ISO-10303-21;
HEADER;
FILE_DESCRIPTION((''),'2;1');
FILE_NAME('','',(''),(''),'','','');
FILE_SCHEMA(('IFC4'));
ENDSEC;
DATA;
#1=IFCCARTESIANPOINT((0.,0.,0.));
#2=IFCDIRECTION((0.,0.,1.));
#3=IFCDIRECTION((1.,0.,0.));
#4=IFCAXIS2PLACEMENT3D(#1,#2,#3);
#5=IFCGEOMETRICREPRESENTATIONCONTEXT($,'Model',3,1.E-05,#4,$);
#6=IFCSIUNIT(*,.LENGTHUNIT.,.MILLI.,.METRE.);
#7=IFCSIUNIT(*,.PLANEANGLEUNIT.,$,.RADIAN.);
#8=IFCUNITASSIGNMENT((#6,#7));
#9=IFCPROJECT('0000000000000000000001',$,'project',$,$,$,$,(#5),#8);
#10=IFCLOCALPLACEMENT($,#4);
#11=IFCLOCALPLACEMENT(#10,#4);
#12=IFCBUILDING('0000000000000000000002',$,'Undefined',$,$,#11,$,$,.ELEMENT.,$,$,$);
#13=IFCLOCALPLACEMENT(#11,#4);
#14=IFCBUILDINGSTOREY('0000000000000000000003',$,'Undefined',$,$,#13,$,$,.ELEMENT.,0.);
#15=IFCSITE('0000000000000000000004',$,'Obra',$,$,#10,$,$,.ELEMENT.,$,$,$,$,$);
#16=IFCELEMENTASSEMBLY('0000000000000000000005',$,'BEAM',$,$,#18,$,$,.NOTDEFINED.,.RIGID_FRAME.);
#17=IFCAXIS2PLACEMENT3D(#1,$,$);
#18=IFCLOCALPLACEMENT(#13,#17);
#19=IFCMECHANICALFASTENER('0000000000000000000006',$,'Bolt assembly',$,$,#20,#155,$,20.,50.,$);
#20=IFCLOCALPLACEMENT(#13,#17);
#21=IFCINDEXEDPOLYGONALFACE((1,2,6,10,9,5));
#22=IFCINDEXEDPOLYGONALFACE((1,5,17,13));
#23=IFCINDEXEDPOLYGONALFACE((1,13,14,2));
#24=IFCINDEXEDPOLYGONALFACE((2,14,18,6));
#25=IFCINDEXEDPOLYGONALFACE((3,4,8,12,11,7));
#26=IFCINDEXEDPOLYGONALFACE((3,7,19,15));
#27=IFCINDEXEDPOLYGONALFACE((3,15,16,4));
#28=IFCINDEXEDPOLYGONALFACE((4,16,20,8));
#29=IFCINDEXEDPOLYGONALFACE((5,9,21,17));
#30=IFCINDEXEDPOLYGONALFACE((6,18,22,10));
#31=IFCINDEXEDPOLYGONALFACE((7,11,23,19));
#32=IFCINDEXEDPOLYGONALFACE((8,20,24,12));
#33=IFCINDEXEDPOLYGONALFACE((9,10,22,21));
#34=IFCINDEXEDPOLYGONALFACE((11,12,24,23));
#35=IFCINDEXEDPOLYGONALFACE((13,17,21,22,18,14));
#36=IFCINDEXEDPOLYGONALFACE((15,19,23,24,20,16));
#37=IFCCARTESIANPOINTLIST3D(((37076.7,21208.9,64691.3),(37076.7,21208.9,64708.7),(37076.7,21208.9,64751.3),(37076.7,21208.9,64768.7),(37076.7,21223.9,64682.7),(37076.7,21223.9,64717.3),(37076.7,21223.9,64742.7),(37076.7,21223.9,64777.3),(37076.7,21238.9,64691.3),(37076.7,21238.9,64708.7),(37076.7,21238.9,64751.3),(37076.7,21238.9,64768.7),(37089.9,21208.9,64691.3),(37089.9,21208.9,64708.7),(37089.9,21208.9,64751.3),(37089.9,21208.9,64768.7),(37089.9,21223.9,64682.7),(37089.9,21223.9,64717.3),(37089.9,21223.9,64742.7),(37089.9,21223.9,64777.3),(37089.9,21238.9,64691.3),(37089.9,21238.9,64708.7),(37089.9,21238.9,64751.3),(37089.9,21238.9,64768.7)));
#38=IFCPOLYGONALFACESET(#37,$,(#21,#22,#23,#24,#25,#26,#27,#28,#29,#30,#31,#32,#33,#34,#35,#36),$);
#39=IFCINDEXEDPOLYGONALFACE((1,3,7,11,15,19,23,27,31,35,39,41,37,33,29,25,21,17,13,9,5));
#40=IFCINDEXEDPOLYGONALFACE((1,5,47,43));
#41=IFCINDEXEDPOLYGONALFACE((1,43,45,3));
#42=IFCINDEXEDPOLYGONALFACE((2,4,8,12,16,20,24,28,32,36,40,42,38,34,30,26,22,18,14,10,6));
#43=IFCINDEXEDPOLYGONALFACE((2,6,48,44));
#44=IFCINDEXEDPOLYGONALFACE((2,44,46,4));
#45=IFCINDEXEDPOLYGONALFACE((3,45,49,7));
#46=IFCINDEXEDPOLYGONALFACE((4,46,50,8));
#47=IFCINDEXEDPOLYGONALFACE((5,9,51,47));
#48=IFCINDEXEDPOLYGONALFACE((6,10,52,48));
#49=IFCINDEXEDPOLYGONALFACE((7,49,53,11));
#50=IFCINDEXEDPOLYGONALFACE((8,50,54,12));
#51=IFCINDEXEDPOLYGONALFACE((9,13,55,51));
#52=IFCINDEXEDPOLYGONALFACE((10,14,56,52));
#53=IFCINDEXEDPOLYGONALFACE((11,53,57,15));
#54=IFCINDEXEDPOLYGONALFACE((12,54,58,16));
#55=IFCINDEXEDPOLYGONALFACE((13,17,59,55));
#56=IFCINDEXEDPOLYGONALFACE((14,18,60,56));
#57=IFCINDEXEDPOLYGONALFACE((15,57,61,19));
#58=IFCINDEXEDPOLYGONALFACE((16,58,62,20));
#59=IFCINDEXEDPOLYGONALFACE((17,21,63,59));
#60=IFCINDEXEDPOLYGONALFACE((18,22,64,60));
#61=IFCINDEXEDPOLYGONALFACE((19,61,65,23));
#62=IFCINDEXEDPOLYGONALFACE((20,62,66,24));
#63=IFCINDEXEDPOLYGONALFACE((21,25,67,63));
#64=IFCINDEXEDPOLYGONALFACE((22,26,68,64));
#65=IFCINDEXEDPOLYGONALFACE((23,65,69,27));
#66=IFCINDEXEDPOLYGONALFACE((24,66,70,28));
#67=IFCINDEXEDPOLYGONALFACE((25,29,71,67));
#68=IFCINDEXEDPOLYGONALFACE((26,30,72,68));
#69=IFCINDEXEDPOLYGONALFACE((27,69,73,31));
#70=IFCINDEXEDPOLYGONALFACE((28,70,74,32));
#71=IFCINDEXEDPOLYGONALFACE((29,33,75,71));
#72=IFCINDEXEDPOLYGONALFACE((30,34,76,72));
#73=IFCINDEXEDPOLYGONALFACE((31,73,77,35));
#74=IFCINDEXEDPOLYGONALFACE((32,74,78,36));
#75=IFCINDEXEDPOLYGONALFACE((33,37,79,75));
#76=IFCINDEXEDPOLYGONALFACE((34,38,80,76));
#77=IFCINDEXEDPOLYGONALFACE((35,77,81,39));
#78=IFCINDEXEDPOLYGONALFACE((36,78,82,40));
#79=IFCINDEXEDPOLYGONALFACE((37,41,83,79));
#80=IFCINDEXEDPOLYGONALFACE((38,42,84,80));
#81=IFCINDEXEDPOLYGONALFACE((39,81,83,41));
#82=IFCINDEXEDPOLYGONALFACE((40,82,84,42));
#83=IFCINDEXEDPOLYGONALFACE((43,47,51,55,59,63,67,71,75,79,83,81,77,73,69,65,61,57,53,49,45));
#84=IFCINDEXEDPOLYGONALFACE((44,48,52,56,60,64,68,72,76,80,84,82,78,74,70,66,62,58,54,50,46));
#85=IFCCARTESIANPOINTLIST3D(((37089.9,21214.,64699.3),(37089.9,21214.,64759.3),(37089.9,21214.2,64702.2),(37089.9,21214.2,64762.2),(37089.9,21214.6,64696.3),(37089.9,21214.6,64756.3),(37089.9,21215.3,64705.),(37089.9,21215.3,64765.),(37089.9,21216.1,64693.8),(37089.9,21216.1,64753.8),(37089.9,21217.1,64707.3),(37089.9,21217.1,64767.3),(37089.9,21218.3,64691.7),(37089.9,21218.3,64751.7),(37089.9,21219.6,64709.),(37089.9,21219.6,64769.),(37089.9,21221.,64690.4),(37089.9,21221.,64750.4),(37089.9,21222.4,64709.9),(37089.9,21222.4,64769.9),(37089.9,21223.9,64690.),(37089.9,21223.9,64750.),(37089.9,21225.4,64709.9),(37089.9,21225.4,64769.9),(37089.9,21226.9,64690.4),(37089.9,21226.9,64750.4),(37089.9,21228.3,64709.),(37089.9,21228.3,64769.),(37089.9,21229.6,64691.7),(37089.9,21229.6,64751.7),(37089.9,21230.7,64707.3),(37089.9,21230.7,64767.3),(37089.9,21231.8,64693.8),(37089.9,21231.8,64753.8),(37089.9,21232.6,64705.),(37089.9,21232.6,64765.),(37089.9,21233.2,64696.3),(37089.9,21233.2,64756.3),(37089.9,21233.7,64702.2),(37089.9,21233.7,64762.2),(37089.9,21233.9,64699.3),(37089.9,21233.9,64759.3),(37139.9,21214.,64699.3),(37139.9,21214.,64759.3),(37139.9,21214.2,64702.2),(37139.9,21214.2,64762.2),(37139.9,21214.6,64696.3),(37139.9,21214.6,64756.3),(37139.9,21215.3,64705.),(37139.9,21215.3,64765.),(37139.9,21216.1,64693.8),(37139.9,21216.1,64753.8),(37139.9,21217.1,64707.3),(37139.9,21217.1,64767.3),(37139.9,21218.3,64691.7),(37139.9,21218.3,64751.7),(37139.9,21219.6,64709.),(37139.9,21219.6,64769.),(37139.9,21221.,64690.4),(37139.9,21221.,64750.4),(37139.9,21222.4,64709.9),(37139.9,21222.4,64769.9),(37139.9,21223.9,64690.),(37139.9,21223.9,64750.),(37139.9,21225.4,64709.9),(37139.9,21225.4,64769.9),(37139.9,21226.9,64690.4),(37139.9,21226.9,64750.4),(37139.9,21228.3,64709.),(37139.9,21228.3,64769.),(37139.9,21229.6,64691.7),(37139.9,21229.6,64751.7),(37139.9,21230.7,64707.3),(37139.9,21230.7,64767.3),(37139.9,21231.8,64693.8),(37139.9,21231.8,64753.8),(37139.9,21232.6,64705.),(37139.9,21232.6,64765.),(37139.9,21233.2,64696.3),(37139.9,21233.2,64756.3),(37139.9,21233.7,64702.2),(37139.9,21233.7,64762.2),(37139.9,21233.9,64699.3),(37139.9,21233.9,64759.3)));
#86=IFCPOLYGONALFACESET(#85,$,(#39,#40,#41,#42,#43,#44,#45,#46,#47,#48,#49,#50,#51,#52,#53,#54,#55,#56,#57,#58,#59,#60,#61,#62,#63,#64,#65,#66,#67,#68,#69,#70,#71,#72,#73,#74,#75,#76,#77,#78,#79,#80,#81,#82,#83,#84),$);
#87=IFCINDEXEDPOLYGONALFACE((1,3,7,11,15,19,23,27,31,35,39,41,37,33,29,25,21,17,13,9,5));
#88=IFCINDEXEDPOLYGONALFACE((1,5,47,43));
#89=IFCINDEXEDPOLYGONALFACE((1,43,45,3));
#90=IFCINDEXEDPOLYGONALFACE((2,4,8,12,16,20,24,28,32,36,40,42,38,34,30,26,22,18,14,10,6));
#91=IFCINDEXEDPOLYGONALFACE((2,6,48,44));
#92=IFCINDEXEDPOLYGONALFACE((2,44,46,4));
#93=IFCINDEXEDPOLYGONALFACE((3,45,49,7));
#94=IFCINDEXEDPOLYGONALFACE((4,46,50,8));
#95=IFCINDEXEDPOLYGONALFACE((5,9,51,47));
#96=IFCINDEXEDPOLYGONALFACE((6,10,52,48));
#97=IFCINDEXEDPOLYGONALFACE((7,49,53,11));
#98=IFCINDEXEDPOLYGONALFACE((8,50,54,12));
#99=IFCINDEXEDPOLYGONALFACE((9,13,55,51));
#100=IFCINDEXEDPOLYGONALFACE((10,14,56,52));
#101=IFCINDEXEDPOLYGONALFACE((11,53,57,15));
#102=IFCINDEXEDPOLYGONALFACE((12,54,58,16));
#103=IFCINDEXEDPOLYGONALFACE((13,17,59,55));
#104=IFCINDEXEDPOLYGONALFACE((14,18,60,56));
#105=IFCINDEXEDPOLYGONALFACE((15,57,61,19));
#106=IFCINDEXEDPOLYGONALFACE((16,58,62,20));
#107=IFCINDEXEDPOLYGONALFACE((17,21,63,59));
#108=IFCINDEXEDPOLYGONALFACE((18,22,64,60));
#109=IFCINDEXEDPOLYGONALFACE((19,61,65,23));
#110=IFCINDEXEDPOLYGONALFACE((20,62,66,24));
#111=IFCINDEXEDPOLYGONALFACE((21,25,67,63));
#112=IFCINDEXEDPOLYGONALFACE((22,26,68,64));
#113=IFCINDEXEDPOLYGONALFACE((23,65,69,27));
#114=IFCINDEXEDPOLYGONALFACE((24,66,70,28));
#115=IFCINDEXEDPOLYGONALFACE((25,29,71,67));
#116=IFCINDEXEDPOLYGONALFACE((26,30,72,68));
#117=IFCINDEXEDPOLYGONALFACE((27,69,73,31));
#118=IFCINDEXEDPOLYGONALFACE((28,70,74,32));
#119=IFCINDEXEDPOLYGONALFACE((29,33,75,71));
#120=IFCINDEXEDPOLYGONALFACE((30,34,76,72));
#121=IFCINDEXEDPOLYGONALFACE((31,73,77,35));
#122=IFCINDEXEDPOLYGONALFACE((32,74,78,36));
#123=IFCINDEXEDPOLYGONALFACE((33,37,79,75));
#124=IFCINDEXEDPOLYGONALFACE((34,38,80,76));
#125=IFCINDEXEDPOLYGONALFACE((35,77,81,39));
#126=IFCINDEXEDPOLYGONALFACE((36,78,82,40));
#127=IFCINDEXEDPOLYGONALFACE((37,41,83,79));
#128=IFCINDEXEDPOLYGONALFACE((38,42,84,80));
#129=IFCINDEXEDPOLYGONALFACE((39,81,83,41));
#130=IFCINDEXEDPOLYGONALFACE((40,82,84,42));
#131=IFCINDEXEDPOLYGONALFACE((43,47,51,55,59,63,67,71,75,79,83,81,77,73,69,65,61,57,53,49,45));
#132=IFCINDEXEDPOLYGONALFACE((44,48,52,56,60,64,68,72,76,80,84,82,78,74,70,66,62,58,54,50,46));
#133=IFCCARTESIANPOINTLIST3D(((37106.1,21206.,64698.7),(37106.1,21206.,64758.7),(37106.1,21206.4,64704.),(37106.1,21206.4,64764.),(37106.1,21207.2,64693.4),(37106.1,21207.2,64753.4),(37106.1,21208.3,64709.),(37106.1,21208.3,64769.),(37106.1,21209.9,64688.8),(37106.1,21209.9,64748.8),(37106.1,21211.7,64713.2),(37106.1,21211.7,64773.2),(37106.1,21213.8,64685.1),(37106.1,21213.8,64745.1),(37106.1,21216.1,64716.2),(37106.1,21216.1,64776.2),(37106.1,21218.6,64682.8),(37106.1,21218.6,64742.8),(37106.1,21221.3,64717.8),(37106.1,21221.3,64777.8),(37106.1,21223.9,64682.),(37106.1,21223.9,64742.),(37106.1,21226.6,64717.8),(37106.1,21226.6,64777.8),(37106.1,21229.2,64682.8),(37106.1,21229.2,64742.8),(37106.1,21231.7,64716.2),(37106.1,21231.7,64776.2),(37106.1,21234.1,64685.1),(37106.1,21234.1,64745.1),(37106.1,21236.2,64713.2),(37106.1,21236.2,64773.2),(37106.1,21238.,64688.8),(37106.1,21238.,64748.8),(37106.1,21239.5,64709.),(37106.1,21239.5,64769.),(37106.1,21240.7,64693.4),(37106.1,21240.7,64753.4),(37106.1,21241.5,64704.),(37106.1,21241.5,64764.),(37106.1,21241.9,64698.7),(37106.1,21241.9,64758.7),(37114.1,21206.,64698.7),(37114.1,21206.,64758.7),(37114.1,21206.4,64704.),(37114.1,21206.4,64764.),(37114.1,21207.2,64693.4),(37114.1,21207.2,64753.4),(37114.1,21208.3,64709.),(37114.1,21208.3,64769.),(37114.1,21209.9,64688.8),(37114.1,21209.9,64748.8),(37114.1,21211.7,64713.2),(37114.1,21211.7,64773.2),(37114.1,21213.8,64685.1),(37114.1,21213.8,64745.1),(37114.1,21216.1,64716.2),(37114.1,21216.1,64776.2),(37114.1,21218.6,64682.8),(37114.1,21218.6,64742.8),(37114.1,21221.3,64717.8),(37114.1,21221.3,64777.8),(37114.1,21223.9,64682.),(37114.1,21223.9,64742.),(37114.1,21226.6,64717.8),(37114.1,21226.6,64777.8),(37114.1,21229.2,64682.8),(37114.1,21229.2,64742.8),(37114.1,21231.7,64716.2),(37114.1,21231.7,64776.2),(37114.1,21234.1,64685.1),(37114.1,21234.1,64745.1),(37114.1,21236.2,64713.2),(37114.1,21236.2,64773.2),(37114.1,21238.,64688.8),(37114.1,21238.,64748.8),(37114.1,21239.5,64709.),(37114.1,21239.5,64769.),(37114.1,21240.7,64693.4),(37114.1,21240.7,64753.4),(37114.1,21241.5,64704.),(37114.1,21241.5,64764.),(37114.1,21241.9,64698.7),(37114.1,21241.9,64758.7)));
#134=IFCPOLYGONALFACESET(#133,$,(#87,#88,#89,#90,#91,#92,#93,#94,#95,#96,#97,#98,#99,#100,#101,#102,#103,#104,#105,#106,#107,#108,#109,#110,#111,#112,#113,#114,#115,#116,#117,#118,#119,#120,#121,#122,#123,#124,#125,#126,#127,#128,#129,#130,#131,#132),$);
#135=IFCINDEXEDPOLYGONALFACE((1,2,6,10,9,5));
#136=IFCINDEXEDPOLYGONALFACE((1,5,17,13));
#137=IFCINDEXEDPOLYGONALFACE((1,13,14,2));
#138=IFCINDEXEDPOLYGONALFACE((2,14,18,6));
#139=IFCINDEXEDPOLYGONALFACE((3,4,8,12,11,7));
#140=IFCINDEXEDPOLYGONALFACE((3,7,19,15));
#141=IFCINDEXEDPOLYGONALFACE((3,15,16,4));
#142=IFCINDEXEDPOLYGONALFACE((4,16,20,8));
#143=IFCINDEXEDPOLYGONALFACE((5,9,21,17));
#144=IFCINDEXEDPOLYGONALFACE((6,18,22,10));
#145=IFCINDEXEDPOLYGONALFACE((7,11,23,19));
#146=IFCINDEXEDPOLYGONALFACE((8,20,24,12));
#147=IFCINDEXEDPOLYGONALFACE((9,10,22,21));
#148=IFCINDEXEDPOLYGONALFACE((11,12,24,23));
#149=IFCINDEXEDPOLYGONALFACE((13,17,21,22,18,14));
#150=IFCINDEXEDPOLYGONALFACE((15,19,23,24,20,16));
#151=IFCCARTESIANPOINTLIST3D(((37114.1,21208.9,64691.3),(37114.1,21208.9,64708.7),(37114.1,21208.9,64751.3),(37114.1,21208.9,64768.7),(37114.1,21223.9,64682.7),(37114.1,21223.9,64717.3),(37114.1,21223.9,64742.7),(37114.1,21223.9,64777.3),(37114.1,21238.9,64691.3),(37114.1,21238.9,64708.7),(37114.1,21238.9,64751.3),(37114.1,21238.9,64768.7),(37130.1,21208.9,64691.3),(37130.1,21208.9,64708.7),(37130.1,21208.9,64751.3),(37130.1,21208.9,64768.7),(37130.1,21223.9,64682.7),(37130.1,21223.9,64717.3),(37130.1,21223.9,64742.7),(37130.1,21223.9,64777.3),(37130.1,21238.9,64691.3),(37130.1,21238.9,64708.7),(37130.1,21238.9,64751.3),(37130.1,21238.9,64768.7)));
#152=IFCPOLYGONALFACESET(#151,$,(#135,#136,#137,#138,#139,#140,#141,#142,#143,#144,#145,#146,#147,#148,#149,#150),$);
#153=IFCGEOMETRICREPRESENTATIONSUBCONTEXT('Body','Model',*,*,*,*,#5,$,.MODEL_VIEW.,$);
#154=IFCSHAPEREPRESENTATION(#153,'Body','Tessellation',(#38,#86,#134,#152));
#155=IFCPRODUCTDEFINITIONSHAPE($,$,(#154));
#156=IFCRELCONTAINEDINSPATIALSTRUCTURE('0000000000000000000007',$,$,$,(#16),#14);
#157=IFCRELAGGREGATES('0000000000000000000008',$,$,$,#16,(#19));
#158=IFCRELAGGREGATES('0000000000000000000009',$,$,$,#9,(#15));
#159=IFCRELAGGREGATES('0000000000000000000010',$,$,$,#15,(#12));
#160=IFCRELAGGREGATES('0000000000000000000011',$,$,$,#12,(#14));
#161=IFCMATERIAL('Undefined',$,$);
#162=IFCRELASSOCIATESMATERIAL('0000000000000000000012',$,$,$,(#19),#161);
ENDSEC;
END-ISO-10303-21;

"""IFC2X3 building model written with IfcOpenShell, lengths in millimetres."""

from ifc_helpers import new_model, si_unit, frame, origin_with_axes, origin_2d_with_axis, place, context, subcontext, project, spatial, polyline, circle, outline, extrude, source, transform, mapped, material, element, aggregate, save


model = new_model("IFC2X3")

# Units and contexts
model_context = context("Model", 3, precision=1e-05, world=origin_with_axes())
body_context = subcontext(model_context, "Body", "Model", "MODEL_VIEW")
ifc_project = project(units=[si_unit("LENGTHUNIT", "METRE", prefix="MILLI"), si_unit("PLANEANGLEUNIT", "RADIAN")], contexts=[model_context])

# Site, building, storey
site_placement = place(None, origin_with_axes())
site = spatial("IfcSite", under=ifc_project, at=site_placement, Name="Obra", CompositionType="ELEMENT")
building_placement = place(site_placement, origin_with_axes())
building = spatial("IfcBuilding", under=site, at=building_placement, Name="Undefined", CompositionType="ELEMENT")
storey_placement = place(building_placement, origin_with_axes())
storey = spatial("IfcBuildingStorey", under=building, at=storey_placement, Name="Undefined", CompositionType="ELEMENT", Elevation=0.0)

# Shared definitions
ifc_material = material(Name="Undefined")

# Element assembly, mechanical fastener
assembly_1_placement = place(storey_placement, origin_with_axes())
assembly_1 = element("IfcElementAssembly", 1, at=assembly_1_placement, inside=storey, Name="BEAM", AssemblyPlace="NOTDEFINED", PredefinedType="RIGID_FRAME")
shared_shape_1 = source(origin_with_axes(), body_context, "Body", "SweptSolid", [
    extrude(outline(polyline([(17.3, 0.0), (8.7, 15.0), (-8.7, 15.0), (-17.3, 0.0), (-8.7, -15.0), (8.7, -15.0), (17.3, 0.0)])), frame((0.0, -26.3, 0.0), z_axis=(0.0, 1.0, 0.0), x_axis=(1.0, 0.0, 0.0)), (0.0, 0.0, 1.0), 13.2),
    extrude(circle(Radius=10.0, at=origin_2d_with_axis()), frame((0.0, -13.1, 0.0), z_axis=(0.0, 1.0, 0.0), x_axis=(1.0, 0.0, 0.0)), (0.0, 0.0, 1.0), 50.0),
    extrude(circle(Radius=18.0, at=origin_2d_with_axis()), frame((0.0, 3.1, 0.0), z_axis=(0.0, 1.0, 0.0), x_axis=(1.0, 0.0, 0.0)), (0.0, 0.0, 1.0), 8.0),
    extrude(outline(polyline([(17.3, 0.0), (8.7, 15.0), (-8.7, 15.0), (-17.3, 0.0), (-8.7, -15.0), (8.7, -15.0), (17.3, 0.0)])), frame((0.0, 11.1, 0.0), z_axis=(0.0, 1.0, 0.0), x_axis=(1.0, 0.0, 0.0)), (0.0, 0.0, 1.0), 16.0),
])
mechanical_fastener_1_placement = place(assembly_1_placement, frame((37103.0, 21263.9, 64850.0), z_axis=(0.0, -1.0, 0.0), x_axis=(0.0, 0.0, -1.0)))
mechanical_fastener_1 = element("IfcMechanicalFastener", 2, at=mechanical_fastener_1_placement, material=ifc_material, Name="Bolt assembly", NominalDiameter=20.0, NominalLength=50.0, context=body_context, shape_type="MappedRepresentation", body=[
    mapped(shared_shape_1, transform((90.0, 0.0, 40.0))),
    mapped(shared_shape_1, transform((150.0, 0.0, 40.0))),
])

aggregate(assembly_1, [mechanical_fastener_1])

save(model, "model.ifc")
